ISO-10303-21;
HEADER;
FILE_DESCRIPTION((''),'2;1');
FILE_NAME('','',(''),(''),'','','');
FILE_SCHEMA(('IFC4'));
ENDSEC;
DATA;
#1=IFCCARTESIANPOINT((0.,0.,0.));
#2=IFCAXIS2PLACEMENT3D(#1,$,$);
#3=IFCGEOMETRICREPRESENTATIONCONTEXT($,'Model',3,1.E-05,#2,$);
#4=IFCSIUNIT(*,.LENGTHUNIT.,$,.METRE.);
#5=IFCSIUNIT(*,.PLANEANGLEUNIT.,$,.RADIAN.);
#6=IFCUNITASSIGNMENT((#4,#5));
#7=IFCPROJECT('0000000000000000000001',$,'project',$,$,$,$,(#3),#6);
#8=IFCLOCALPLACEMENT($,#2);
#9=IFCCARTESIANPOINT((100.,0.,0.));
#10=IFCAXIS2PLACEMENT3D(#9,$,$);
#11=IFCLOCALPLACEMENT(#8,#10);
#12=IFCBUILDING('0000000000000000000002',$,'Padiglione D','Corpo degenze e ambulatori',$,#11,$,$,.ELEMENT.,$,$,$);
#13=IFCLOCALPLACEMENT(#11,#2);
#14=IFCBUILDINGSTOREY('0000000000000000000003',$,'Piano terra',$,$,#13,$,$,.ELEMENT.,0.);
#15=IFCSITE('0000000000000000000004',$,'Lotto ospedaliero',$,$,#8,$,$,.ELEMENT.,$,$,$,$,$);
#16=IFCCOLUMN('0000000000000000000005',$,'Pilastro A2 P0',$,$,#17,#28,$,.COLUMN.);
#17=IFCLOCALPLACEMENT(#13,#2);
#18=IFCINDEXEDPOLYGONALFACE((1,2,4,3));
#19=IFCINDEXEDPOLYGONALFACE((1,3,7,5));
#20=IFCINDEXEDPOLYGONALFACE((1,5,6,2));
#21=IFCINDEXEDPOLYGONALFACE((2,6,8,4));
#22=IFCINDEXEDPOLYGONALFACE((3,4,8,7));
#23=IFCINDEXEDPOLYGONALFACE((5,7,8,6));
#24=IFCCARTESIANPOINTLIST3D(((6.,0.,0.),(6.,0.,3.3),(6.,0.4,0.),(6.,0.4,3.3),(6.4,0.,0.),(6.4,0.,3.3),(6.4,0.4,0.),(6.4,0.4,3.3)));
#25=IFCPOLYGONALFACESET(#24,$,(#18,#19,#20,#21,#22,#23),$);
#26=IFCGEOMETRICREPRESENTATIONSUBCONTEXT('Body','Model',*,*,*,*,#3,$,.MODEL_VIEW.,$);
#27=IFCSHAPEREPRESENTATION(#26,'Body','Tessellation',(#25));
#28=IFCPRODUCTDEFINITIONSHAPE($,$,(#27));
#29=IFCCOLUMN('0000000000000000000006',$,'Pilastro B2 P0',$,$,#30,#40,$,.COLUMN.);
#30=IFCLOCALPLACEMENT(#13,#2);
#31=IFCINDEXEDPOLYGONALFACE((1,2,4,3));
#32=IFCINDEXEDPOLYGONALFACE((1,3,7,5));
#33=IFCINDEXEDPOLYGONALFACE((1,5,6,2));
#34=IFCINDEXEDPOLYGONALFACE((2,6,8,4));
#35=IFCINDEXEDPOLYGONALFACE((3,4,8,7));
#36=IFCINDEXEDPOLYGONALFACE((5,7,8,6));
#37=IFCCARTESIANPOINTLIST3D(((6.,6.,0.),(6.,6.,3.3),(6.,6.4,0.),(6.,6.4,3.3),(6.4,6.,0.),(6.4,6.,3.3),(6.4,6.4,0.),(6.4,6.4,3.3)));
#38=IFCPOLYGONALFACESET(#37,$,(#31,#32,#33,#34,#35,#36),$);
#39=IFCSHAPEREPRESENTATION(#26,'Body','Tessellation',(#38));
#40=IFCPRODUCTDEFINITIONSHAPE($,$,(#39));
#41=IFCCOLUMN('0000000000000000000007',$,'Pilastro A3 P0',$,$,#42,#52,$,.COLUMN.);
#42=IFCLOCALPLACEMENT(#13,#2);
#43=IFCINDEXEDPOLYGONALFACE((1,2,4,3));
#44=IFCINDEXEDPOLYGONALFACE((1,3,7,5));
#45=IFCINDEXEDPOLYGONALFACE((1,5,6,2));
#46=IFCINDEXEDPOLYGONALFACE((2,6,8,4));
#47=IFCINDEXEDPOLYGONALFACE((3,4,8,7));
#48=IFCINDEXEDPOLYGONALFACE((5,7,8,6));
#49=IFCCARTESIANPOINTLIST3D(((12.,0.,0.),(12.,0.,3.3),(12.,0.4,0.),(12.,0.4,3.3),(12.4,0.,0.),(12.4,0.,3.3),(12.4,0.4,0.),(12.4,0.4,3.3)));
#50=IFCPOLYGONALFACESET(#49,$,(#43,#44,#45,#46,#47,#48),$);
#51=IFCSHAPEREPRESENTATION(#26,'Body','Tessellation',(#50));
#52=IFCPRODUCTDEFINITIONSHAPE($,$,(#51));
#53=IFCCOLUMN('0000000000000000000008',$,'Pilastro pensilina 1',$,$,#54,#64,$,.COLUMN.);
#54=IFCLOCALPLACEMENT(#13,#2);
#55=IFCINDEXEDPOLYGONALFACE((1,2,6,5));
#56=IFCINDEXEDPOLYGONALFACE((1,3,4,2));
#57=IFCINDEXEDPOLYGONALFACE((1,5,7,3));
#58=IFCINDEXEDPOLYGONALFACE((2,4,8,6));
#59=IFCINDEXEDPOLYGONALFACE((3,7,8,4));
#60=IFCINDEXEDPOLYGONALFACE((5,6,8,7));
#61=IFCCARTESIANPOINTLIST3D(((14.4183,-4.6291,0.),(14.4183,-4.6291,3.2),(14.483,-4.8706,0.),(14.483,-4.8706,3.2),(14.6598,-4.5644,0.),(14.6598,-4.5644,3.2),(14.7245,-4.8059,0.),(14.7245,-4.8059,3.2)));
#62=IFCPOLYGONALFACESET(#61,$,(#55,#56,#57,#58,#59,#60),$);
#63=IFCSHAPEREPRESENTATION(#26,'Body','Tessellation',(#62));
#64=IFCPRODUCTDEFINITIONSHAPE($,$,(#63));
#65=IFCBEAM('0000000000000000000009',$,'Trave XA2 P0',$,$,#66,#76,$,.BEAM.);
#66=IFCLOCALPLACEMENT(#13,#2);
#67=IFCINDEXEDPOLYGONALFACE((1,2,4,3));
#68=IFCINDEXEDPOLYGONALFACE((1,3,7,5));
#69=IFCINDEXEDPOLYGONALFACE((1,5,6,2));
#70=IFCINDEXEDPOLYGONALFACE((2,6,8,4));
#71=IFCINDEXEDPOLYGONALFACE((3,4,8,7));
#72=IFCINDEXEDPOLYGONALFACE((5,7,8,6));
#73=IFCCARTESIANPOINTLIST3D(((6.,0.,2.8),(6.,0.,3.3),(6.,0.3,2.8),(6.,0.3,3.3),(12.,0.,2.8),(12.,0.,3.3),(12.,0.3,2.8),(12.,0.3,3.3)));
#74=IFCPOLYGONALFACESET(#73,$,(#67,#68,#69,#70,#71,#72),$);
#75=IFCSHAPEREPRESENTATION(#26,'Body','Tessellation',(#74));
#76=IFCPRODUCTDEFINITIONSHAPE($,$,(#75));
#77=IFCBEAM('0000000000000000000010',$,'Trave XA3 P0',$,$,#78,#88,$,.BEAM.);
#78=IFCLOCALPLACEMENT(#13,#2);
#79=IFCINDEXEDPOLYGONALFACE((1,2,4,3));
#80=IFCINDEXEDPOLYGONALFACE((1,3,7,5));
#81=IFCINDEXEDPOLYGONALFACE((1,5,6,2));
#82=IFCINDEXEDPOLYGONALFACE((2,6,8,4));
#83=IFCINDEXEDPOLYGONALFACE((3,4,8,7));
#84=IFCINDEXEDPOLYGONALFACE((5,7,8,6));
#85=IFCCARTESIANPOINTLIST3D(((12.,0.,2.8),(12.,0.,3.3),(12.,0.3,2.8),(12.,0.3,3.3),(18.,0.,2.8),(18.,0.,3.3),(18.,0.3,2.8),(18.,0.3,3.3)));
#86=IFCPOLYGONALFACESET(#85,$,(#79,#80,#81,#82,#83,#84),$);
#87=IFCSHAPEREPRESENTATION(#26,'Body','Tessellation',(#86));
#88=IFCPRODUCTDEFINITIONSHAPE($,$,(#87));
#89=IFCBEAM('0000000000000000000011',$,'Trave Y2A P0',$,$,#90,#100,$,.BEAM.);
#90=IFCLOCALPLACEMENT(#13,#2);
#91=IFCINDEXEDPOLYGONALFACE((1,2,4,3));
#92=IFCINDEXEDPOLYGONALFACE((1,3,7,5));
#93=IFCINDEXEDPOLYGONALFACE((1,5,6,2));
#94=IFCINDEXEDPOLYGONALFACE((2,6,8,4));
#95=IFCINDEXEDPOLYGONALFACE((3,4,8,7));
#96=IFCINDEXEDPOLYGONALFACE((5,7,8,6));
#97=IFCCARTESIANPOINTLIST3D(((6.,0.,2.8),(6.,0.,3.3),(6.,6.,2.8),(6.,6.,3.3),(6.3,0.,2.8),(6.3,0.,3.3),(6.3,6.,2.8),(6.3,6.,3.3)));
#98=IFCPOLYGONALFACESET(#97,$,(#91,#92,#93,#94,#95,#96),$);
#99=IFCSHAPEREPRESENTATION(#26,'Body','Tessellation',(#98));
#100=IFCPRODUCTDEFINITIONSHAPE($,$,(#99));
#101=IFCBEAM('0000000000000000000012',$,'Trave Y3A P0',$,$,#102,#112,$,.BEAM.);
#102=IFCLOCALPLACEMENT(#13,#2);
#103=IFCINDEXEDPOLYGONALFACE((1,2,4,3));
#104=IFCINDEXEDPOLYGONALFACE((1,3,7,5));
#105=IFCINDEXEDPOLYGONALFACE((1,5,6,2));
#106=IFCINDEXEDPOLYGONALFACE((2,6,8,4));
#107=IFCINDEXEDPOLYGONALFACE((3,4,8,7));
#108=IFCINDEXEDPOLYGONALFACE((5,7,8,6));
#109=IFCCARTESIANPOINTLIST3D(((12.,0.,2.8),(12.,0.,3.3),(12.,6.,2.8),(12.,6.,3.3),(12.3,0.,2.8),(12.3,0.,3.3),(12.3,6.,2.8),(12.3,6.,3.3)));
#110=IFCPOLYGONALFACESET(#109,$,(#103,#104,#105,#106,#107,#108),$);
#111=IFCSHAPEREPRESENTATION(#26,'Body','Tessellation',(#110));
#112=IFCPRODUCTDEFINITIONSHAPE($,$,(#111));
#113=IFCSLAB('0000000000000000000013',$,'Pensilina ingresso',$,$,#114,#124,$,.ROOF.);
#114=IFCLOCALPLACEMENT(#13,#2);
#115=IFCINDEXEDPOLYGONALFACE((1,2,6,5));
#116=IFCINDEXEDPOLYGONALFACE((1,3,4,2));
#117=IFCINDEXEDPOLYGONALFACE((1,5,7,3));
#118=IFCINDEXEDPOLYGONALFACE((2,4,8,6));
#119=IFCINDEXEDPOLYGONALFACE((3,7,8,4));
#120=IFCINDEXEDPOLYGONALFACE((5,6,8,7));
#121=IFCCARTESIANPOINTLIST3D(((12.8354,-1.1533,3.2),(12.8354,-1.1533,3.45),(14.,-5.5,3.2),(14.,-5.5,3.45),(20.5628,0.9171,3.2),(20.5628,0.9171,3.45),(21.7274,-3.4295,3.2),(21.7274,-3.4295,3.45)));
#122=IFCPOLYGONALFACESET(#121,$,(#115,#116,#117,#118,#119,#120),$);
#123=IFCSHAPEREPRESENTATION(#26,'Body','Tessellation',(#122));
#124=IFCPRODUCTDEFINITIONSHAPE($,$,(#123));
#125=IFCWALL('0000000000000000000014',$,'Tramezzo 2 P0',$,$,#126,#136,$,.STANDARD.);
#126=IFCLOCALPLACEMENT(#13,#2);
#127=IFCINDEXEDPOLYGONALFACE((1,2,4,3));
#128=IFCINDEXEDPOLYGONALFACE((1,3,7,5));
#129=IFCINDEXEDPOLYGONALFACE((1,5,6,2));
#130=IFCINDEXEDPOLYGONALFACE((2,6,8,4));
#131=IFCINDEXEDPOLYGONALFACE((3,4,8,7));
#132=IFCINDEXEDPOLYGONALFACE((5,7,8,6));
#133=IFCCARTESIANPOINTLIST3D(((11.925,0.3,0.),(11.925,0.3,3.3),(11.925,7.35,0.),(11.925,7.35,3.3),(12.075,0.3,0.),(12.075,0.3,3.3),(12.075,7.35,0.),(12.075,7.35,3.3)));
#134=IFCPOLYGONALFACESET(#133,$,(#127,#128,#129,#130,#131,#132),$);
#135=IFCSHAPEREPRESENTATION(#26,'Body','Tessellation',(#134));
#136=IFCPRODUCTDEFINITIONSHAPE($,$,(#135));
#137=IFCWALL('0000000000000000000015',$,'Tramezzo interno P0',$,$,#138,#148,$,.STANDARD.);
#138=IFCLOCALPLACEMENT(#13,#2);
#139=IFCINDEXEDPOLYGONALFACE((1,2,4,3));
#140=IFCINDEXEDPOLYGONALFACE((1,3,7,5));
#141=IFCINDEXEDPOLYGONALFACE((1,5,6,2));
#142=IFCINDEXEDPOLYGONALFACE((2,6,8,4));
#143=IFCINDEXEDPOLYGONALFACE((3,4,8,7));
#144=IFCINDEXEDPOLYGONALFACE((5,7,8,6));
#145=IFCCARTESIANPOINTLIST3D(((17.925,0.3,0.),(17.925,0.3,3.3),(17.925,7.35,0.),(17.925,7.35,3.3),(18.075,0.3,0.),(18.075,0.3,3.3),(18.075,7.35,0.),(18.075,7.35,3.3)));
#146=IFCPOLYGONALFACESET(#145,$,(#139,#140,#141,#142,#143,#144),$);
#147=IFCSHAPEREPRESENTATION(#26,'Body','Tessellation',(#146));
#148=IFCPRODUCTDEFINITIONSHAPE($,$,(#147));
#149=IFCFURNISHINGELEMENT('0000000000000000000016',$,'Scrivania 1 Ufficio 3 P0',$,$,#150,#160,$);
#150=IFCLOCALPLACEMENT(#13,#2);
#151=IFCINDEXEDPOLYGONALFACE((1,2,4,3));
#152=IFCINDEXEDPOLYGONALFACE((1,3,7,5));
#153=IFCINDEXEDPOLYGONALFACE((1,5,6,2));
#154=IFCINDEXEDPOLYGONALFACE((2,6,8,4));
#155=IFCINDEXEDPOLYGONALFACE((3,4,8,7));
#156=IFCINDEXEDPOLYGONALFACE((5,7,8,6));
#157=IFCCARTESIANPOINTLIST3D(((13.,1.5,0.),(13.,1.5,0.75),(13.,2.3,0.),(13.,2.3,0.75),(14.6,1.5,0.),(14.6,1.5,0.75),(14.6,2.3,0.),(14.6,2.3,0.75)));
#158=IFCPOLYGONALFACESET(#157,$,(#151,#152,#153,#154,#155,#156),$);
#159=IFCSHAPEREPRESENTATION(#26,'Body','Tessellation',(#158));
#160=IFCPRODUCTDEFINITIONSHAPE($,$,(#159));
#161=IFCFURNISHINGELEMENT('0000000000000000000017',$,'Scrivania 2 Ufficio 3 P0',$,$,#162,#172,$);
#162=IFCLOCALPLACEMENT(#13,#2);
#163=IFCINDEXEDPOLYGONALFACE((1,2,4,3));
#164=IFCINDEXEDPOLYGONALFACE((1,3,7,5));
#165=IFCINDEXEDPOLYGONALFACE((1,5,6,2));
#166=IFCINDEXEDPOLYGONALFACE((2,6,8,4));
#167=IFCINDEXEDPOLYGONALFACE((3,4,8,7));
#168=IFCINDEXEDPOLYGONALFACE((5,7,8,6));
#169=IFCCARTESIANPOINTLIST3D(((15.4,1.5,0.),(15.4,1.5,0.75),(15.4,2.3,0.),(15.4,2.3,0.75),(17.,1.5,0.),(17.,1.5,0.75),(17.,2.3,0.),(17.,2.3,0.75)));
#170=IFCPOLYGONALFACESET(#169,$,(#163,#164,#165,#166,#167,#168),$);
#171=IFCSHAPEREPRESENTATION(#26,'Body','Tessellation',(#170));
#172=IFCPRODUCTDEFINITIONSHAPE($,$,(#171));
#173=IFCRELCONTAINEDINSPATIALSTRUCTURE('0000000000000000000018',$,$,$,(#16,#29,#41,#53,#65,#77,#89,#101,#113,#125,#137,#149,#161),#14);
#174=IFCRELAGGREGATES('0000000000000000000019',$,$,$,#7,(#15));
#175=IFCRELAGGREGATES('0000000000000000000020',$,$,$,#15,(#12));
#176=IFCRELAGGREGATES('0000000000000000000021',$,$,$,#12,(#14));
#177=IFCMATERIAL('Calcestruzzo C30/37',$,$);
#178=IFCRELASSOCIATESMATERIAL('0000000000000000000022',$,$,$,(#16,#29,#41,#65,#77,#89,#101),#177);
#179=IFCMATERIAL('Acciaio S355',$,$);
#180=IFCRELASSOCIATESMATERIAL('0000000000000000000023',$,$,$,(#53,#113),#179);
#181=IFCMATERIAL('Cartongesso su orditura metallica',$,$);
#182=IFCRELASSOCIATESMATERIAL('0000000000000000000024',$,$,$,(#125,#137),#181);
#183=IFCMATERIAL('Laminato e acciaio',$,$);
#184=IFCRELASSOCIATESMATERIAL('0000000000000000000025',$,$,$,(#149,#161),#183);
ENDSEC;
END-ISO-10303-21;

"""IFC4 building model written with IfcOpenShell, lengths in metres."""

from ifc_helpers import new_model, si_unit, frame, frame_2d, origin, place, context, subcontext, project, spatial, rectangle, extrude, material, element, save


model = new_model("IFC4")

# Units and contexts
model_context = context("Model", 3, precision=1e-05, world=origin())
body_context = subcontext(model_context, "Body", "Model", "MODEL_VIEW")
ifc_project = project(units=[si_unit("LENGTHUNIT", "METRE"), si_unit("PLANEANGLEUNIT", "RADIAN")], contexts=[model_context])

# Site, building, storey
site_placement = place(None, origin())
site = spatial("IfcSite", under=ifc_project, at=site_placement, Name="Lotto ospedaliero", CompositionType="ELEMENT")
building_placement = place(site_placement, frame((100.0, 0.0, 0.0)))
building = spatial("IfcBuilding", under=site, at=building_placement, Name="Padiglione D", Description="Corpo degenze e ambulatori", CompositionType="ELEMENT")
storey_placement = place(building_placement, origin())
storey = spatial("IfcBuildingStorey", under=building, at=storey_placement, Name="Piano terra", CompositionType="ELEMENT", Elevation=0.0)

# Columns
ifc_material_1 = material(Name="Calcestruzzo C30/37")
for number, where, name in (
    (1, (6.0, 0.0, 0.0), "Pilastro A2 P0"),
    (2, (6.0, 6.0, 0.0), "Pilastro B2 P0"),
    (3, (12.0, 0.0, 0.0), "Pilastro A3 P0"),
):
    element("IfcColumn", number, at=place(storey_placement, frame(where)), inside=storey, material=ifc_material_1, Name=name, PredefinedType="COLUMN", context=body_context, shape_type="SweptSolid", body=[
        extrude(rectangle(XDim=0.4, YDim=0.4, at=frame_2d((0.2, 0.2))), origin(), (0.0, 0.0, 1.0), 3.3),
    ])
ifc_material_2 = material(Name="Acciaio S355")
column_placement = place(storey_placement, frame((14.483, -4.8706, 0.0), z_axis=(0.0, 0.0, 1.0), x_axis=(0.9659, 0.2588, 0.0)))
element("IfcColumn", 4, at=column_placement, inside=storey, material=ifc_material_2, Name="Pilastro pensilina 1", PredefinedType="COLUMN", context=body_context, shape_type="SweptSolid", body=[
    extrude(rectangle(XDim=0.25, YDim=0.25, at=frame_2d((0.125, 0.125))), origin(), (0.0, 0.0, 1.0), 3.2),
])

# Beams
for number, where, name in (
    (5, (6.0, 0.0, 2.8), "Trave XA2 P0"),
    (6, (12.0, 0.0, 2.8), "Trave XA3 P0"),
):
    element("IfcBeam", number, at=place(storey_placement, frame(where)), inside=storey, material=ifc_material_1, Name=name, PredefinedType="BEAM", context=body_context, shape_type="SweptSolid", body=[
        extrude(rectangle(XDim=6.0, YDim=0.3, at=frame_2d((3.0, 0.15))), origin(), (0.0, 0.0, 1.0), 0.5),
    ])
for number, where, name in (
    (7, (6.0, 0.0, 2.8), "Trave Y2A P0"),
    (8, (12.0, 0.0, 2.8), "Trave Y3A P0"),
):
    element("IfcBeam", number, at=place(storey_placement, frame(where)), inside=storey, material=ifc_material_1, Name=name, PredefinedType="BEAM", context=body_context, shape_type="SweptSolid", body=[
        extrude(rectangle(XDim=0.3, YDim=6.0, at=frame_2d((0.15, 3.0))), origin(), (0.0, 0.0, 1.0), 0.5),
    ])

# Slab
slab_placement = place(storey_placement, frame((14.0, -5.5, 3.2), z_axis=(0.0, 0.0, 1.0), x_axis=(0.9659, 0.2588, 0.0)))
element("IfcSlab", 9, at=slab_placement, inside=storey, material=ifc_material_2, Name="Pensilina ingresso", PredefinedType="ROOF", context=body_context, shape_type="SweptSolid", body=[
    extrude(rectangle(XDim=8.0, YDim=4.5, at=frame_2d((4.0, 2.25))), origin(), (0.0, 0.0, 1.0), 0.25),
])

# Walls
ifc_material_3 = material(Name="Cartongesso su orditura metallica")
for number, where, name in (
    (10, (11.925, 0.3, 0.0), "Tramezzo 2 P0"),
    (11, (17.925, 0.3, 0.0), "Tramezzo interno P0"),
):
    element("IfcWall", number, at=place(storey_placement, frame(where)), inside=storey, material=ifc_material_3, Name=name, PredefinedType="STANDARD", context=body_context, shape_type="SweptSolid", body=[
        extrude(rectangle(XDim=0.15, YDim=7.05, at=frame_2d((0.075, 3.525))), origin(), (0.0, 0.0, 1.0), 3.3),
    ])

# Furnishing elements
ifc_material_4 = material(Name="Laminato e acciaio")
for number, where, name in (
    (12, (13.0, 1.5, 0.0), "Scrivania 1 Ufficio 3 P0"),
    (13, (15.4, 1.5, 0.0), "Scrivania 2 Ufficio 3 P0"),
):
    element("IfcFurnishingElement", number, at=place(storey_placement, frame(where)), inside=storey, material=ifc_material_4, Name=name, context=body_context, shape_type="SweptSolid", body=[
        extrude(rectangle(XDim=1.6, YDim=0.8, at=frame_2d((0.8, 0.4))), origin(), (0.0, 0.0, 1.0), 0.75),
    ])

save(model, "model.ifc")
